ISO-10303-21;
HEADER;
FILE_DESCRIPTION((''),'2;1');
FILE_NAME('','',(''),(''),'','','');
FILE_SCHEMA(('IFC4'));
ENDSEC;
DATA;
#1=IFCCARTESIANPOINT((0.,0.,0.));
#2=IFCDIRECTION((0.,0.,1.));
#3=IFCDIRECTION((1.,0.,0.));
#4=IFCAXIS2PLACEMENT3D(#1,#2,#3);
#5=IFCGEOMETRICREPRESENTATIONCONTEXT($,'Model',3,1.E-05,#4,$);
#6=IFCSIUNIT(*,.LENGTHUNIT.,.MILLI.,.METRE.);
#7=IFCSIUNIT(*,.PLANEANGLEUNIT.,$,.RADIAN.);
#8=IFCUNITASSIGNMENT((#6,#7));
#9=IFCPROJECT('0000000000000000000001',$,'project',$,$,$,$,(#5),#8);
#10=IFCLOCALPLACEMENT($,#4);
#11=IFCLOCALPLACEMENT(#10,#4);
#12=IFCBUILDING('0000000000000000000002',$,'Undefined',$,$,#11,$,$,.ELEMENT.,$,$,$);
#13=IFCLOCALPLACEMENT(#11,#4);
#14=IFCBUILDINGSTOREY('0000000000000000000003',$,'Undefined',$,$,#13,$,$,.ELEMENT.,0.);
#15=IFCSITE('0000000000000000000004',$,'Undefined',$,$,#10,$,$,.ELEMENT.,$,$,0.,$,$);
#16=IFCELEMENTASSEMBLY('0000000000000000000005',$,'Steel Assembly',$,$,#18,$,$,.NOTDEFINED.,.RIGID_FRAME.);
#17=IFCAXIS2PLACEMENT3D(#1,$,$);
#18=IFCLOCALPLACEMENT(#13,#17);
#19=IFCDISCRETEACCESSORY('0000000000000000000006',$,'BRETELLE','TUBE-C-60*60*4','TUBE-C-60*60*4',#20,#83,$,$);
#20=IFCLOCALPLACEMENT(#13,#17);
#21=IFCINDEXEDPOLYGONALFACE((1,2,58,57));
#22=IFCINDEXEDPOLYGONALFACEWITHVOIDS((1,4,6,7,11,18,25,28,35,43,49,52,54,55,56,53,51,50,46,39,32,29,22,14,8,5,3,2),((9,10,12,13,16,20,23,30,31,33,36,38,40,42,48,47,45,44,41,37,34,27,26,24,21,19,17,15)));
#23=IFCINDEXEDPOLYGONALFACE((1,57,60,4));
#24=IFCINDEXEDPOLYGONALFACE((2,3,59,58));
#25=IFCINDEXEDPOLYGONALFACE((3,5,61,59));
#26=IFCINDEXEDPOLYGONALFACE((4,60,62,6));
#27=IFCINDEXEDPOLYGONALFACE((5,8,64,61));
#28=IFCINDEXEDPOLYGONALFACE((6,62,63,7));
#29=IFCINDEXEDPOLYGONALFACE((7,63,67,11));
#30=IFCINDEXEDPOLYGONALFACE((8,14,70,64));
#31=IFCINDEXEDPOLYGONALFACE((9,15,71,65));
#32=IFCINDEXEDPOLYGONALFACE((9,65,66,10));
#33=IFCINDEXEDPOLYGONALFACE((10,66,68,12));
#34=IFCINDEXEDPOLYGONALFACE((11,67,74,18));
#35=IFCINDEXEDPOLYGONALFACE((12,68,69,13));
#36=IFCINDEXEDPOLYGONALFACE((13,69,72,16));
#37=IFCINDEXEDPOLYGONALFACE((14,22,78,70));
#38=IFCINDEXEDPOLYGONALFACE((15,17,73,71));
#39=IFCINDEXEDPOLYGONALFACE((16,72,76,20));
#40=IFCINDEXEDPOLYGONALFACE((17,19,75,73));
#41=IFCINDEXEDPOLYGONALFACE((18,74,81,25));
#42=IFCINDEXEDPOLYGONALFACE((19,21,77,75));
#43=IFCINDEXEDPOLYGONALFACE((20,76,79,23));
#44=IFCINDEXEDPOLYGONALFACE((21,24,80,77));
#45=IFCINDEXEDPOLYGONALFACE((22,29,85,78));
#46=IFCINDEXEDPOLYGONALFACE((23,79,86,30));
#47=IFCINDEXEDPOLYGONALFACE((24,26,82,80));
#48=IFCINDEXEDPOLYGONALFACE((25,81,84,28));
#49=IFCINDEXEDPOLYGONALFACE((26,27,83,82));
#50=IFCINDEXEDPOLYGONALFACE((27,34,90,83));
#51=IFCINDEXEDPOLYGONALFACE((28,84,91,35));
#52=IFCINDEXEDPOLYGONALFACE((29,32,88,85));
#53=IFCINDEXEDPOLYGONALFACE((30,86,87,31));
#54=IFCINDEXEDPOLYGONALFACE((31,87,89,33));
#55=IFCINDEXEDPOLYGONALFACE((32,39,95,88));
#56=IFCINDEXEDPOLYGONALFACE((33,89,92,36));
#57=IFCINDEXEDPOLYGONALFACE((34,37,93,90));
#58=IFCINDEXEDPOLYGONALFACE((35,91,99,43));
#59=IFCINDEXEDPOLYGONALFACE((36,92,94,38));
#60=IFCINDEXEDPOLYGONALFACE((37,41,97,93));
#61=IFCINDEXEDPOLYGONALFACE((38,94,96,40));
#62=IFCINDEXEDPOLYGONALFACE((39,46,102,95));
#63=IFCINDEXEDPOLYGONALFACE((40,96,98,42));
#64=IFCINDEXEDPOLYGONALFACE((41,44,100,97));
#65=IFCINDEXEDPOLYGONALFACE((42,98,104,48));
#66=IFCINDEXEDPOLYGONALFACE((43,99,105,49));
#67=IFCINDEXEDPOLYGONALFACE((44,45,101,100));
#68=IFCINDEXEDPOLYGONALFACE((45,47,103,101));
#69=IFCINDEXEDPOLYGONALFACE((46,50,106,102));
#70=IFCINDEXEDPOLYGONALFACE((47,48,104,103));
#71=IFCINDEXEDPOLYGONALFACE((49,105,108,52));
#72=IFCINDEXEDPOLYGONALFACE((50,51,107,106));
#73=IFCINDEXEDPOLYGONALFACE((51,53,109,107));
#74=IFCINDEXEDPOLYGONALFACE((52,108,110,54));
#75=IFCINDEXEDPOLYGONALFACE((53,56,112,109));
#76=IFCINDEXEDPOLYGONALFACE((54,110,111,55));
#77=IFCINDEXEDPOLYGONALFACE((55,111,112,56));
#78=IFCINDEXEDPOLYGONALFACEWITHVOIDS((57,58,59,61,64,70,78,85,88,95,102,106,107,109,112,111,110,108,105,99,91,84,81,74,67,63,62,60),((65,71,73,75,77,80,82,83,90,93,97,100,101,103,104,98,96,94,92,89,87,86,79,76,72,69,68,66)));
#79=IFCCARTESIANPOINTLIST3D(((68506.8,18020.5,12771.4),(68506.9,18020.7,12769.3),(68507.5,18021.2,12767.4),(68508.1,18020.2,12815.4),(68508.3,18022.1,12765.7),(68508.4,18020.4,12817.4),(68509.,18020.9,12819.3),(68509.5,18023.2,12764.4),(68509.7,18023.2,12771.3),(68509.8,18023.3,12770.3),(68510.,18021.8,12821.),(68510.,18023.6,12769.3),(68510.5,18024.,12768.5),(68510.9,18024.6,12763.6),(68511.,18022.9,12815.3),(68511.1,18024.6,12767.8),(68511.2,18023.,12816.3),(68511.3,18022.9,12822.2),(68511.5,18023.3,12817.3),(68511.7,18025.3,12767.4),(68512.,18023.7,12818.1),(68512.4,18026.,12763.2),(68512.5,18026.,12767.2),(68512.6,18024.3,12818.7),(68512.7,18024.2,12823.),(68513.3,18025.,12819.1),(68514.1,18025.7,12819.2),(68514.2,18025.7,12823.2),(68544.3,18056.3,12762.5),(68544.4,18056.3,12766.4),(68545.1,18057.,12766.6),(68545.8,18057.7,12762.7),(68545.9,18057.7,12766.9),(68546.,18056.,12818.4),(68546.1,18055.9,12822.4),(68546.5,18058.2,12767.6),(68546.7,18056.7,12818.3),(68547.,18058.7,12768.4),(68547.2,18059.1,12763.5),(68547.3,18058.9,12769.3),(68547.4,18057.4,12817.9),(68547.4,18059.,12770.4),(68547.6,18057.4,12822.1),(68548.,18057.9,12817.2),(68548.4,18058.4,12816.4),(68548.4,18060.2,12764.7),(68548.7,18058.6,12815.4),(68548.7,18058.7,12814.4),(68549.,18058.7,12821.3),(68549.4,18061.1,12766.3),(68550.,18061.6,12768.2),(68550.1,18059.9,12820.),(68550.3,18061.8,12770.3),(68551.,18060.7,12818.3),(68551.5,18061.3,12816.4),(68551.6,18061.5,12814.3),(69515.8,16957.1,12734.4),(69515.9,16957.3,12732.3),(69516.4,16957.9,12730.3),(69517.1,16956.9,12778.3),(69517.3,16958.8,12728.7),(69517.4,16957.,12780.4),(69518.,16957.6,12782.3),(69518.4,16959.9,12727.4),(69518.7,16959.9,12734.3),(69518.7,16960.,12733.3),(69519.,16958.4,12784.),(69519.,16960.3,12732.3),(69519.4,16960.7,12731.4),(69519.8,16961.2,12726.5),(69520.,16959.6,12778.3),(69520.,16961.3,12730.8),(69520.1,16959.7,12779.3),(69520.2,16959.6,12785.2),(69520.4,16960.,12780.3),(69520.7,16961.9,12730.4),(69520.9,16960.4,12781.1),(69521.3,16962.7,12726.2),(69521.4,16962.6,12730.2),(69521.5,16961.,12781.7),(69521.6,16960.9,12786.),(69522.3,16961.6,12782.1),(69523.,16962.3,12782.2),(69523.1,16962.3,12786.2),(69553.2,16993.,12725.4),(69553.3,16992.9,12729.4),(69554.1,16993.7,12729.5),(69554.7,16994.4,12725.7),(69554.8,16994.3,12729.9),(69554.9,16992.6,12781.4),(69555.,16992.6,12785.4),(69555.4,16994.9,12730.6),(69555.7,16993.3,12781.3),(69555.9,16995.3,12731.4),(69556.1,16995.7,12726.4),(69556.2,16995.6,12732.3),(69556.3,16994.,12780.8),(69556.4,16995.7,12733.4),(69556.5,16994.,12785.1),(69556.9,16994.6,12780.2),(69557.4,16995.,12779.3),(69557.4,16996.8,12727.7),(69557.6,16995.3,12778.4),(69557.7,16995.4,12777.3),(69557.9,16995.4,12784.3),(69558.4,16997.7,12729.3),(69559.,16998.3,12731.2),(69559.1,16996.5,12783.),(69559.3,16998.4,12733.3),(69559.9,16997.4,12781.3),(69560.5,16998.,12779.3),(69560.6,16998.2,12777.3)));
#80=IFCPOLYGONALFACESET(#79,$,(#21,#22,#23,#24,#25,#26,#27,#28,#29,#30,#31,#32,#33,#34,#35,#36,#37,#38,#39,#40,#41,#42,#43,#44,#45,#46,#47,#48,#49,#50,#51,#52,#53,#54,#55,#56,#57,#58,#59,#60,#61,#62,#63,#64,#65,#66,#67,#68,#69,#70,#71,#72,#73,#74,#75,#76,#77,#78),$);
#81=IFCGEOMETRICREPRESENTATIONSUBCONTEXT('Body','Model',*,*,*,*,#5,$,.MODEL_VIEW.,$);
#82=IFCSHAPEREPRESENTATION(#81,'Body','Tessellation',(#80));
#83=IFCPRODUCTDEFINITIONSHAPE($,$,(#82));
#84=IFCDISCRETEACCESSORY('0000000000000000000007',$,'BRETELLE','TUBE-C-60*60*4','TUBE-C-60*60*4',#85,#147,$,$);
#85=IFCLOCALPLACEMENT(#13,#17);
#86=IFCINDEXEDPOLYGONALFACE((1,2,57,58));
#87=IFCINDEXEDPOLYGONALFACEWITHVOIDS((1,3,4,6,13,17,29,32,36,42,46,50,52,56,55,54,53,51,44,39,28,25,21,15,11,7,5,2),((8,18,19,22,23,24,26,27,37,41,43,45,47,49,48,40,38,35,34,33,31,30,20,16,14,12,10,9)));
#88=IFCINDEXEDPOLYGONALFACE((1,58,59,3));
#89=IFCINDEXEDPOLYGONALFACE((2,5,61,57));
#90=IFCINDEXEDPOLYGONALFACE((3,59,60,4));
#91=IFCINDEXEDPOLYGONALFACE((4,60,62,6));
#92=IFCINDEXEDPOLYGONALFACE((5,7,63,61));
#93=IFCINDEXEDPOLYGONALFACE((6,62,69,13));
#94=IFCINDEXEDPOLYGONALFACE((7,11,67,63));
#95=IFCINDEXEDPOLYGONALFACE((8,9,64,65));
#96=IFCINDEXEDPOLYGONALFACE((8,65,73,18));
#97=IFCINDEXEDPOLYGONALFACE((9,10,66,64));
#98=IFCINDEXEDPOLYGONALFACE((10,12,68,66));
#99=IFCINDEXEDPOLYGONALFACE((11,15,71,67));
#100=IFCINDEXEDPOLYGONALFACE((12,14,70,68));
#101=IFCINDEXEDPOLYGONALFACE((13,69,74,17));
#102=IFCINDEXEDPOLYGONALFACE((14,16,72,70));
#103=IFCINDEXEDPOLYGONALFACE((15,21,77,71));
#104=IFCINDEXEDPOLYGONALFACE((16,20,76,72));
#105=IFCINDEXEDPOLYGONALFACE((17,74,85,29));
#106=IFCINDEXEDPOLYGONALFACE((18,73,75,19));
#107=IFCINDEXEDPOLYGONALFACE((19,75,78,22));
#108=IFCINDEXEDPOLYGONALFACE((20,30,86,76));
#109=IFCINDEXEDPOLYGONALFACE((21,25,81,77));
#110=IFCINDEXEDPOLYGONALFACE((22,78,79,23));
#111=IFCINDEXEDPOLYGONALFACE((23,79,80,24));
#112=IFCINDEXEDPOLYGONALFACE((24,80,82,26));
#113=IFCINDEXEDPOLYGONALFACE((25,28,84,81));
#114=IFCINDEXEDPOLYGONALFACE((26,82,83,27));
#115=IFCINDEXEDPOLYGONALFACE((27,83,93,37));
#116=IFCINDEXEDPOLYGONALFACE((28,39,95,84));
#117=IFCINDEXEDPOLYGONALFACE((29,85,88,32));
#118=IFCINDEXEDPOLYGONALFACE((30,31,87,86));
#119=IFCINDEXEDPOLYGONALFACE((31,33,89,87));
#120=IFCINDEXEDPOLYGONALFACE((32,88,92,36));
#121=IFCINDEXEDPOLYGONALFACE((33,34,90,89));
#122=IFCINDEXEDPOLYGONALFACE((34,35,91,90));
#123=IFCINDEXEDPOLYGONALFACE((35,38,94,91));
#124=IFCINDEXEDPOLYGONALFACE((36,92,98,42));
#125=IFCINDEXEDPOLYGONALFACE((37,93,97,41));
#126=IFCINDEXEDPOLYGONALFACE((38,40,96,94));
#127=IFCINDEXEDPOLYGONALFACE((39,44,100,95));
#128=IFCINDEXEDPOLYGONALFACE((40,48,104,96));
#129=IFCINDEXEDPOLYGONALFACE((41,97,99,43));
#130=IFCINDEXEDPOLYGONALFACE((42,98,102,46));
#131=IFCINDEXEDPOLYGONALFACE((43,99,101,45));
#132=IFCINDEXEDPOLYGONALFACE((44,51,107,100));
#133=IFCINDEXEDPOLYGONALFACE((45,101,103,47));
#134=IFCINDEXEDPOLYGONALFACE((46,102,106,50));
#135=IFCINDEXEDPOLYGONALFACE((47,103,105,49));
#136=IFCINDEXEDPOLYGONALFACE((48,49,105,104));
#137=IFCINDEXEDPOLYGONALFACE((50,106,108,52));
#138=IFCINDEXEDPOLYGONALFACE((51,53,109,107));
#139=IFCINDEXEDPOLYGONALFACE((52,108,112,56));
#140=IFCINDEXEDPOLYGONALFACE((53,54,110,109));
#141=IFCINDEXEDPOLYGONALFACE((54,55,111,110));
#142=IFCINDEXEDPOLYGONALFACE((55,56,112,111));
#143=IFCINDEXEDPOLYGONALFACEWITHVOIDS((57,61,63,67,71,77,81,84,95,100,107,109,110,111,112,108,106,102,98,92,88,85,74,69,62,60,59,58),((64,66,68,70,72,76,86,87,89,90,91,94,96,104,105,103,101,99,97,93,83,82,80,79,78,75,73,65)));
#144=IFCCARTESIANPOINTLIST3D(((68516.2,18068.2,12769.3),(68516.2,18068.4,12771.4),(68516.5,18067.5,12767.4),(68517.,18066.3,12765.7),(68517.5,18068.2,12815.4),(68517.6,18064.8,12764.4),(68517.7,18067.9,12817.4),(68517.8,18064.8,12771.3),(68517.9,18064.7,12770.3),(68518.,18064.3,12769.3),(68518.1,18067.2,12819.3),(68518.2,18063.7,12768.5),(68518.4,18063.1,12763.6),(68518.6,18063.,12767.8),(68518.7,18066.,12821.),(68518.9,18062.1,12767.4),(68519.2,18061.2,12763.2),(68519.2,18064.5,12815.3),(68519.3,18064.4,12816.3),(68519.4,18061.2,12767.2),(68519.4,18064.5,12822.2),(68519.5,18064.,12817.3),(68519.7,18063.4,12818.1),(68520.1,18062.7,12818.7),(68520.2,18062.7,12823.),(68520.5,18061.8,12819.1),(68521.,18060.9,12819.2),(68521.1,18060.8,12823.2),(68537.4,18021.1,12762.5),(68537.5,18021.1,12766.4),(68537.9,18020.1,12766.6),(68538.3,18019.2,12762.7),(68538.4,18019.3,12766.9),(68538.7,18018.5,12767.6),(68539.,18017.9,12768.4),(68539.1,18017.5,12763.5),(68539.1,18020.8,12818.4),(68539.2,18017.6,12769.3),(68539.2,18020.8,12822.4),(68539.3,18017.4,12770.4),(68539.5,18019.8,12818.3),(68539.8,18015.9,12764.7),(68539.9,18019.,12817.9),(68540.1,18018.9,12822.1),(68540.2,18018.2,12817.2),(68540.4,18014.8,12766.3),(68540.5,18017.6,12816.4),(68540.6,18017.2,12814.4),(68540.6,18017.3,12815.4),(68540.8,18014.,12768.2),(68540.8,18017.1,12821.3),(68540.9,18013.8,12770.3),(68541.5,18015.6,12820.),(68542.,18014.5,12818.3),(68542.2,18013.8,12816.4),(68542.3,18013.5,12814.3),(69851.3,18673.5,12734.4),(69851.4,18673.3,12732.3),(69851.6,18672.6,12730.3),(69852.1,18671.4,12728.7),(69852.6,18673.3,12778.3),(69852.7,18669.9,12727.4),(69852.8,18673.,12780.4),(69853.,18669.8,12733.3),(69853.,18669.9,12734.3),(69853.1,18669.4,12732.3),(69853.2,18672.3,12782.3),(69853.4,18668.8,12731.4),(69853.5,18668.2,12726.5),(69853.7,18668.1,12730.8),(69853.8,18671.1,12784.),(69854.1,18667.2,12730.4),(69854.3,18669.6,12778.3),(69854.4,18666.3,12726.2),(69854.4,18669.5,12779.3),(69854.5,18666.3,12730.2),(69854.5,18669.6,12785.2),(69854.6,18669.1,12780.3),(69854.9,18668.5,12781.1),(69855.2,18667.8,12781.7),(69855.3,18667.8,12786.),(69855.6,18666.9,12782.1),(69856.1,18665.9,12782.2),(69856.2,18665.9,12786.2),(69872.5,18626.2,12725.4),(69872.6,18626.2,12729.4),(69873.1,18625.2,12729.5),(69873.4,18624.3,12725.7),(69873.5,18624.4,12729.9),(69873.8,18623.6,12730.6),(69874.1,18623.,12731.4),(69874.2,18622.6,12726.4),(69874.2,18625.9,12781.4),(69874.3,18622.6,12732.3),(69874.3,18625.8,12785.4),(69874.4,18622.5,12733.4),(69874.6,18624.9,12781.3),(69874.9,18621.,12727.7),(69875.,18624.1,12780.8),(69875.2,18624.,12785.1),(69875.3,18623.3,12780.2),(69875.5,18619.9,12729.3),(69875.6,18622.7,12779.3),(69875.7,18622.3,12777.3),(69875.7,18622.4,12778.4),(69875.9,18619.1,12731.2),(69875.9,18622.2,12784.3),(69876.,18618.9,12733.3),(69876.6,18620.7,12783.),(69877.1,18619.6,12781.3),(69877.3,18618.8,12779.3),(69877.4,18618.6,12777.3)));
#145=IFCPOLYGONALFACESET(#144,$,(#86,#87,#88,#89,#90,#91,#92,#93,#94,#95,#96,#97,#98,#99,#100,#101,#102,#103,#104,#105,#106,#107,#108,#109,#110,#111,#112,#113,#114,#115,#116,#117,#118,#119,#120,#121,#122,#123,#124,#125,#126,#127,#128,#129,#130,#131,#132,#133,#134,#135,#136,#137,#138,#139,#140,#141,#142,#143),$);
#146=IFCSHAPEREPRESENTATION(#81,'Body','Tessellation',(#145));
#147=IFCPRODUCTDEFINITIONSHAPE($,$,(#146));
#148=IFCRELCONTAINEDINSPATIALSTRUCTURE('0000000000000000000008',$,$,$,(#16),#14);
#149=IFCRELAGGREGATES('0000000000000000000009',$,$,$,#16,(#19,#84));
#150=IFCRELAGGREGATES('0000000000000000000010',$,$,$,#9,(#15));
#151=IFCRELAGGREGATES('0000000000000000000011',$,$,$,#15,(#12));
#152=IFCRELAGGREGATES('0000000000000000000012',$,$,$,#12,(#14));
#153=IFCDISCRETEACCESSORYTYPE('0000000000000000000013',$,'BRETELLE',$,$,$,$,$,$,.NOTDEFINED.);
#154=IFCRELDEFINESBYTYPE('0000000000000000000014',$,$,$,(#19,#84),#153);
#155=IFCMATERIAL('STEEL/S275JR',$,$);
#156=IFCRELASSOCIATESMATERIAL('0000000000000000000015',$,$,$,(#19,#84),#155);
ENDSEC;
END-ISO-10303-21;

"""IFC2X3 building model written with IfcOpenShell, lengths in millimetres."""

from ifc_helpers import new_model, si_unit, frame, origin_with_axes, origin_2d_with_axis, place, context, subcontext, project, spatial, hollow_rectangle, extrude, material, type_object, element, aggregate, save


model = new_model("IFC2X3")

# Units and contexts
model_context = context("Model", 3, precision=1e-05, world=origin_with_axes())
body_context = subcontext(model_context, "Body", "Model", "MODEL_VIEW")
ifc_project = project(units=[si_unit("LENGTHUNIT", "METRE", prefix="MILLI"), si_unit("PLANEANGLEUNIT", "RADIAN")], contexts=[model_context])

# Site, building, storey
site_placement = place(None, origin_with_axes())
site = spatial("IfcSite", under=ifc_project, at=site_placement, Name="Undefined", CompositionType="ELEMENT", RefElevation=0.0)
building_placement = place(site_placement, origin_with_axes())
building = spatial("IfcBuilding", under=site, at=building_placement, Name="Undefined", CompositionType="ELEMENT")
storey_placement = place(building_placement, origin_with_axes())
storey = spatial("IfcBuildingStorey", under=building, at=storey_placement, Name="Undefined", CompositionType="ELEMENT", Elevation=0.0)

# Shared definitions
ifc_material = material(Name="STEEL/S275JR")

# Element assembly, discrete accessories
assembly_1_placement = place(storey_placement, origin_with_axes())
assembly_1 = element("IfcElementAssembly", 1, at=assembly_1_placement, inside=storey, Name="Steel Assembly", AssemblyPlace="NOTDEFINED", PredefinedType="RIGID_FRAME")
discrete_accessory_type_1 = type_object("IfcDiscreteAccessoryType", Name="BRETELLE")
discrete_accessory_1_placement = place(assembly_1_placement, frame((68529.2, 18041.0, 12792.8), z_axis=(0.724985, 0.68853, -0.017961), x_axis=(0.688093, -0.725184, -0.025247)))
discrete_accessory_1 = element("IfcDiscreteAccessory", 2, at=discrete_accessory_1_placement, type_object=discrete_accessory_type_1, material=ifc_material, Name="BRETELLE", Description="TUBE-C-60*60*4", ObjectType="TUBE-C-60*60*4", context=body_context, shape_type="SweptSolid", body=[
    extrude(hollow_rectangle(XDim=60.0, YDim=60.0, WallThickness=4.0, InnerFilletRadius=4.0, OuterFilletRadius=8.0, at=origin_2d_with_axis()), frame((1466.3, 0.0, 0.0), z_axis=(-1.0, 0.0, 0.0), x_axis=(0.0, -1.0, 0.0)), (0.0, 0.0, 1.0), 1466.3),
])
discrete_accessory_2_placement = place(assembly_1_placement, frame((69864.3, 18646.1, 12755.8), z_axis=(-0.412318, 0.910863, 0.017961), x_axis=(-0.910532, -0.412666, 0.025247)))
discrete_accessory_2 = element("IfcDiscreteAccessory", 3, at=discrete_accessory_2_placement, type_object=discrete_accessory_type_1, material=ifc_material, Name="BRETELLE", Description="TUBE-C-60*60*4", ObjectType="TUBE-C-60*60*4", context=body_context, shape_type="SweptSolid", body=[
    extrude(hollow_rectangle(XDim=60.0, YDim=60.0, WallThickness=4.0, InnerFilletRadius=4.0, OuterFilletRadius=8.0, at=origin_2d_with_axis()), frame((1466.3, 0.0, 0.0), z_axis=(-1.0, 0.0, 0.0), x_axis=(0.0, -1.0, 0.0)), (0.0, 0.0, 1.0), 1466.3),
])
aggregate(assembly_1, [discrete_accessory_1, discrete_accessory_2])

save(model, "model.ifc")
